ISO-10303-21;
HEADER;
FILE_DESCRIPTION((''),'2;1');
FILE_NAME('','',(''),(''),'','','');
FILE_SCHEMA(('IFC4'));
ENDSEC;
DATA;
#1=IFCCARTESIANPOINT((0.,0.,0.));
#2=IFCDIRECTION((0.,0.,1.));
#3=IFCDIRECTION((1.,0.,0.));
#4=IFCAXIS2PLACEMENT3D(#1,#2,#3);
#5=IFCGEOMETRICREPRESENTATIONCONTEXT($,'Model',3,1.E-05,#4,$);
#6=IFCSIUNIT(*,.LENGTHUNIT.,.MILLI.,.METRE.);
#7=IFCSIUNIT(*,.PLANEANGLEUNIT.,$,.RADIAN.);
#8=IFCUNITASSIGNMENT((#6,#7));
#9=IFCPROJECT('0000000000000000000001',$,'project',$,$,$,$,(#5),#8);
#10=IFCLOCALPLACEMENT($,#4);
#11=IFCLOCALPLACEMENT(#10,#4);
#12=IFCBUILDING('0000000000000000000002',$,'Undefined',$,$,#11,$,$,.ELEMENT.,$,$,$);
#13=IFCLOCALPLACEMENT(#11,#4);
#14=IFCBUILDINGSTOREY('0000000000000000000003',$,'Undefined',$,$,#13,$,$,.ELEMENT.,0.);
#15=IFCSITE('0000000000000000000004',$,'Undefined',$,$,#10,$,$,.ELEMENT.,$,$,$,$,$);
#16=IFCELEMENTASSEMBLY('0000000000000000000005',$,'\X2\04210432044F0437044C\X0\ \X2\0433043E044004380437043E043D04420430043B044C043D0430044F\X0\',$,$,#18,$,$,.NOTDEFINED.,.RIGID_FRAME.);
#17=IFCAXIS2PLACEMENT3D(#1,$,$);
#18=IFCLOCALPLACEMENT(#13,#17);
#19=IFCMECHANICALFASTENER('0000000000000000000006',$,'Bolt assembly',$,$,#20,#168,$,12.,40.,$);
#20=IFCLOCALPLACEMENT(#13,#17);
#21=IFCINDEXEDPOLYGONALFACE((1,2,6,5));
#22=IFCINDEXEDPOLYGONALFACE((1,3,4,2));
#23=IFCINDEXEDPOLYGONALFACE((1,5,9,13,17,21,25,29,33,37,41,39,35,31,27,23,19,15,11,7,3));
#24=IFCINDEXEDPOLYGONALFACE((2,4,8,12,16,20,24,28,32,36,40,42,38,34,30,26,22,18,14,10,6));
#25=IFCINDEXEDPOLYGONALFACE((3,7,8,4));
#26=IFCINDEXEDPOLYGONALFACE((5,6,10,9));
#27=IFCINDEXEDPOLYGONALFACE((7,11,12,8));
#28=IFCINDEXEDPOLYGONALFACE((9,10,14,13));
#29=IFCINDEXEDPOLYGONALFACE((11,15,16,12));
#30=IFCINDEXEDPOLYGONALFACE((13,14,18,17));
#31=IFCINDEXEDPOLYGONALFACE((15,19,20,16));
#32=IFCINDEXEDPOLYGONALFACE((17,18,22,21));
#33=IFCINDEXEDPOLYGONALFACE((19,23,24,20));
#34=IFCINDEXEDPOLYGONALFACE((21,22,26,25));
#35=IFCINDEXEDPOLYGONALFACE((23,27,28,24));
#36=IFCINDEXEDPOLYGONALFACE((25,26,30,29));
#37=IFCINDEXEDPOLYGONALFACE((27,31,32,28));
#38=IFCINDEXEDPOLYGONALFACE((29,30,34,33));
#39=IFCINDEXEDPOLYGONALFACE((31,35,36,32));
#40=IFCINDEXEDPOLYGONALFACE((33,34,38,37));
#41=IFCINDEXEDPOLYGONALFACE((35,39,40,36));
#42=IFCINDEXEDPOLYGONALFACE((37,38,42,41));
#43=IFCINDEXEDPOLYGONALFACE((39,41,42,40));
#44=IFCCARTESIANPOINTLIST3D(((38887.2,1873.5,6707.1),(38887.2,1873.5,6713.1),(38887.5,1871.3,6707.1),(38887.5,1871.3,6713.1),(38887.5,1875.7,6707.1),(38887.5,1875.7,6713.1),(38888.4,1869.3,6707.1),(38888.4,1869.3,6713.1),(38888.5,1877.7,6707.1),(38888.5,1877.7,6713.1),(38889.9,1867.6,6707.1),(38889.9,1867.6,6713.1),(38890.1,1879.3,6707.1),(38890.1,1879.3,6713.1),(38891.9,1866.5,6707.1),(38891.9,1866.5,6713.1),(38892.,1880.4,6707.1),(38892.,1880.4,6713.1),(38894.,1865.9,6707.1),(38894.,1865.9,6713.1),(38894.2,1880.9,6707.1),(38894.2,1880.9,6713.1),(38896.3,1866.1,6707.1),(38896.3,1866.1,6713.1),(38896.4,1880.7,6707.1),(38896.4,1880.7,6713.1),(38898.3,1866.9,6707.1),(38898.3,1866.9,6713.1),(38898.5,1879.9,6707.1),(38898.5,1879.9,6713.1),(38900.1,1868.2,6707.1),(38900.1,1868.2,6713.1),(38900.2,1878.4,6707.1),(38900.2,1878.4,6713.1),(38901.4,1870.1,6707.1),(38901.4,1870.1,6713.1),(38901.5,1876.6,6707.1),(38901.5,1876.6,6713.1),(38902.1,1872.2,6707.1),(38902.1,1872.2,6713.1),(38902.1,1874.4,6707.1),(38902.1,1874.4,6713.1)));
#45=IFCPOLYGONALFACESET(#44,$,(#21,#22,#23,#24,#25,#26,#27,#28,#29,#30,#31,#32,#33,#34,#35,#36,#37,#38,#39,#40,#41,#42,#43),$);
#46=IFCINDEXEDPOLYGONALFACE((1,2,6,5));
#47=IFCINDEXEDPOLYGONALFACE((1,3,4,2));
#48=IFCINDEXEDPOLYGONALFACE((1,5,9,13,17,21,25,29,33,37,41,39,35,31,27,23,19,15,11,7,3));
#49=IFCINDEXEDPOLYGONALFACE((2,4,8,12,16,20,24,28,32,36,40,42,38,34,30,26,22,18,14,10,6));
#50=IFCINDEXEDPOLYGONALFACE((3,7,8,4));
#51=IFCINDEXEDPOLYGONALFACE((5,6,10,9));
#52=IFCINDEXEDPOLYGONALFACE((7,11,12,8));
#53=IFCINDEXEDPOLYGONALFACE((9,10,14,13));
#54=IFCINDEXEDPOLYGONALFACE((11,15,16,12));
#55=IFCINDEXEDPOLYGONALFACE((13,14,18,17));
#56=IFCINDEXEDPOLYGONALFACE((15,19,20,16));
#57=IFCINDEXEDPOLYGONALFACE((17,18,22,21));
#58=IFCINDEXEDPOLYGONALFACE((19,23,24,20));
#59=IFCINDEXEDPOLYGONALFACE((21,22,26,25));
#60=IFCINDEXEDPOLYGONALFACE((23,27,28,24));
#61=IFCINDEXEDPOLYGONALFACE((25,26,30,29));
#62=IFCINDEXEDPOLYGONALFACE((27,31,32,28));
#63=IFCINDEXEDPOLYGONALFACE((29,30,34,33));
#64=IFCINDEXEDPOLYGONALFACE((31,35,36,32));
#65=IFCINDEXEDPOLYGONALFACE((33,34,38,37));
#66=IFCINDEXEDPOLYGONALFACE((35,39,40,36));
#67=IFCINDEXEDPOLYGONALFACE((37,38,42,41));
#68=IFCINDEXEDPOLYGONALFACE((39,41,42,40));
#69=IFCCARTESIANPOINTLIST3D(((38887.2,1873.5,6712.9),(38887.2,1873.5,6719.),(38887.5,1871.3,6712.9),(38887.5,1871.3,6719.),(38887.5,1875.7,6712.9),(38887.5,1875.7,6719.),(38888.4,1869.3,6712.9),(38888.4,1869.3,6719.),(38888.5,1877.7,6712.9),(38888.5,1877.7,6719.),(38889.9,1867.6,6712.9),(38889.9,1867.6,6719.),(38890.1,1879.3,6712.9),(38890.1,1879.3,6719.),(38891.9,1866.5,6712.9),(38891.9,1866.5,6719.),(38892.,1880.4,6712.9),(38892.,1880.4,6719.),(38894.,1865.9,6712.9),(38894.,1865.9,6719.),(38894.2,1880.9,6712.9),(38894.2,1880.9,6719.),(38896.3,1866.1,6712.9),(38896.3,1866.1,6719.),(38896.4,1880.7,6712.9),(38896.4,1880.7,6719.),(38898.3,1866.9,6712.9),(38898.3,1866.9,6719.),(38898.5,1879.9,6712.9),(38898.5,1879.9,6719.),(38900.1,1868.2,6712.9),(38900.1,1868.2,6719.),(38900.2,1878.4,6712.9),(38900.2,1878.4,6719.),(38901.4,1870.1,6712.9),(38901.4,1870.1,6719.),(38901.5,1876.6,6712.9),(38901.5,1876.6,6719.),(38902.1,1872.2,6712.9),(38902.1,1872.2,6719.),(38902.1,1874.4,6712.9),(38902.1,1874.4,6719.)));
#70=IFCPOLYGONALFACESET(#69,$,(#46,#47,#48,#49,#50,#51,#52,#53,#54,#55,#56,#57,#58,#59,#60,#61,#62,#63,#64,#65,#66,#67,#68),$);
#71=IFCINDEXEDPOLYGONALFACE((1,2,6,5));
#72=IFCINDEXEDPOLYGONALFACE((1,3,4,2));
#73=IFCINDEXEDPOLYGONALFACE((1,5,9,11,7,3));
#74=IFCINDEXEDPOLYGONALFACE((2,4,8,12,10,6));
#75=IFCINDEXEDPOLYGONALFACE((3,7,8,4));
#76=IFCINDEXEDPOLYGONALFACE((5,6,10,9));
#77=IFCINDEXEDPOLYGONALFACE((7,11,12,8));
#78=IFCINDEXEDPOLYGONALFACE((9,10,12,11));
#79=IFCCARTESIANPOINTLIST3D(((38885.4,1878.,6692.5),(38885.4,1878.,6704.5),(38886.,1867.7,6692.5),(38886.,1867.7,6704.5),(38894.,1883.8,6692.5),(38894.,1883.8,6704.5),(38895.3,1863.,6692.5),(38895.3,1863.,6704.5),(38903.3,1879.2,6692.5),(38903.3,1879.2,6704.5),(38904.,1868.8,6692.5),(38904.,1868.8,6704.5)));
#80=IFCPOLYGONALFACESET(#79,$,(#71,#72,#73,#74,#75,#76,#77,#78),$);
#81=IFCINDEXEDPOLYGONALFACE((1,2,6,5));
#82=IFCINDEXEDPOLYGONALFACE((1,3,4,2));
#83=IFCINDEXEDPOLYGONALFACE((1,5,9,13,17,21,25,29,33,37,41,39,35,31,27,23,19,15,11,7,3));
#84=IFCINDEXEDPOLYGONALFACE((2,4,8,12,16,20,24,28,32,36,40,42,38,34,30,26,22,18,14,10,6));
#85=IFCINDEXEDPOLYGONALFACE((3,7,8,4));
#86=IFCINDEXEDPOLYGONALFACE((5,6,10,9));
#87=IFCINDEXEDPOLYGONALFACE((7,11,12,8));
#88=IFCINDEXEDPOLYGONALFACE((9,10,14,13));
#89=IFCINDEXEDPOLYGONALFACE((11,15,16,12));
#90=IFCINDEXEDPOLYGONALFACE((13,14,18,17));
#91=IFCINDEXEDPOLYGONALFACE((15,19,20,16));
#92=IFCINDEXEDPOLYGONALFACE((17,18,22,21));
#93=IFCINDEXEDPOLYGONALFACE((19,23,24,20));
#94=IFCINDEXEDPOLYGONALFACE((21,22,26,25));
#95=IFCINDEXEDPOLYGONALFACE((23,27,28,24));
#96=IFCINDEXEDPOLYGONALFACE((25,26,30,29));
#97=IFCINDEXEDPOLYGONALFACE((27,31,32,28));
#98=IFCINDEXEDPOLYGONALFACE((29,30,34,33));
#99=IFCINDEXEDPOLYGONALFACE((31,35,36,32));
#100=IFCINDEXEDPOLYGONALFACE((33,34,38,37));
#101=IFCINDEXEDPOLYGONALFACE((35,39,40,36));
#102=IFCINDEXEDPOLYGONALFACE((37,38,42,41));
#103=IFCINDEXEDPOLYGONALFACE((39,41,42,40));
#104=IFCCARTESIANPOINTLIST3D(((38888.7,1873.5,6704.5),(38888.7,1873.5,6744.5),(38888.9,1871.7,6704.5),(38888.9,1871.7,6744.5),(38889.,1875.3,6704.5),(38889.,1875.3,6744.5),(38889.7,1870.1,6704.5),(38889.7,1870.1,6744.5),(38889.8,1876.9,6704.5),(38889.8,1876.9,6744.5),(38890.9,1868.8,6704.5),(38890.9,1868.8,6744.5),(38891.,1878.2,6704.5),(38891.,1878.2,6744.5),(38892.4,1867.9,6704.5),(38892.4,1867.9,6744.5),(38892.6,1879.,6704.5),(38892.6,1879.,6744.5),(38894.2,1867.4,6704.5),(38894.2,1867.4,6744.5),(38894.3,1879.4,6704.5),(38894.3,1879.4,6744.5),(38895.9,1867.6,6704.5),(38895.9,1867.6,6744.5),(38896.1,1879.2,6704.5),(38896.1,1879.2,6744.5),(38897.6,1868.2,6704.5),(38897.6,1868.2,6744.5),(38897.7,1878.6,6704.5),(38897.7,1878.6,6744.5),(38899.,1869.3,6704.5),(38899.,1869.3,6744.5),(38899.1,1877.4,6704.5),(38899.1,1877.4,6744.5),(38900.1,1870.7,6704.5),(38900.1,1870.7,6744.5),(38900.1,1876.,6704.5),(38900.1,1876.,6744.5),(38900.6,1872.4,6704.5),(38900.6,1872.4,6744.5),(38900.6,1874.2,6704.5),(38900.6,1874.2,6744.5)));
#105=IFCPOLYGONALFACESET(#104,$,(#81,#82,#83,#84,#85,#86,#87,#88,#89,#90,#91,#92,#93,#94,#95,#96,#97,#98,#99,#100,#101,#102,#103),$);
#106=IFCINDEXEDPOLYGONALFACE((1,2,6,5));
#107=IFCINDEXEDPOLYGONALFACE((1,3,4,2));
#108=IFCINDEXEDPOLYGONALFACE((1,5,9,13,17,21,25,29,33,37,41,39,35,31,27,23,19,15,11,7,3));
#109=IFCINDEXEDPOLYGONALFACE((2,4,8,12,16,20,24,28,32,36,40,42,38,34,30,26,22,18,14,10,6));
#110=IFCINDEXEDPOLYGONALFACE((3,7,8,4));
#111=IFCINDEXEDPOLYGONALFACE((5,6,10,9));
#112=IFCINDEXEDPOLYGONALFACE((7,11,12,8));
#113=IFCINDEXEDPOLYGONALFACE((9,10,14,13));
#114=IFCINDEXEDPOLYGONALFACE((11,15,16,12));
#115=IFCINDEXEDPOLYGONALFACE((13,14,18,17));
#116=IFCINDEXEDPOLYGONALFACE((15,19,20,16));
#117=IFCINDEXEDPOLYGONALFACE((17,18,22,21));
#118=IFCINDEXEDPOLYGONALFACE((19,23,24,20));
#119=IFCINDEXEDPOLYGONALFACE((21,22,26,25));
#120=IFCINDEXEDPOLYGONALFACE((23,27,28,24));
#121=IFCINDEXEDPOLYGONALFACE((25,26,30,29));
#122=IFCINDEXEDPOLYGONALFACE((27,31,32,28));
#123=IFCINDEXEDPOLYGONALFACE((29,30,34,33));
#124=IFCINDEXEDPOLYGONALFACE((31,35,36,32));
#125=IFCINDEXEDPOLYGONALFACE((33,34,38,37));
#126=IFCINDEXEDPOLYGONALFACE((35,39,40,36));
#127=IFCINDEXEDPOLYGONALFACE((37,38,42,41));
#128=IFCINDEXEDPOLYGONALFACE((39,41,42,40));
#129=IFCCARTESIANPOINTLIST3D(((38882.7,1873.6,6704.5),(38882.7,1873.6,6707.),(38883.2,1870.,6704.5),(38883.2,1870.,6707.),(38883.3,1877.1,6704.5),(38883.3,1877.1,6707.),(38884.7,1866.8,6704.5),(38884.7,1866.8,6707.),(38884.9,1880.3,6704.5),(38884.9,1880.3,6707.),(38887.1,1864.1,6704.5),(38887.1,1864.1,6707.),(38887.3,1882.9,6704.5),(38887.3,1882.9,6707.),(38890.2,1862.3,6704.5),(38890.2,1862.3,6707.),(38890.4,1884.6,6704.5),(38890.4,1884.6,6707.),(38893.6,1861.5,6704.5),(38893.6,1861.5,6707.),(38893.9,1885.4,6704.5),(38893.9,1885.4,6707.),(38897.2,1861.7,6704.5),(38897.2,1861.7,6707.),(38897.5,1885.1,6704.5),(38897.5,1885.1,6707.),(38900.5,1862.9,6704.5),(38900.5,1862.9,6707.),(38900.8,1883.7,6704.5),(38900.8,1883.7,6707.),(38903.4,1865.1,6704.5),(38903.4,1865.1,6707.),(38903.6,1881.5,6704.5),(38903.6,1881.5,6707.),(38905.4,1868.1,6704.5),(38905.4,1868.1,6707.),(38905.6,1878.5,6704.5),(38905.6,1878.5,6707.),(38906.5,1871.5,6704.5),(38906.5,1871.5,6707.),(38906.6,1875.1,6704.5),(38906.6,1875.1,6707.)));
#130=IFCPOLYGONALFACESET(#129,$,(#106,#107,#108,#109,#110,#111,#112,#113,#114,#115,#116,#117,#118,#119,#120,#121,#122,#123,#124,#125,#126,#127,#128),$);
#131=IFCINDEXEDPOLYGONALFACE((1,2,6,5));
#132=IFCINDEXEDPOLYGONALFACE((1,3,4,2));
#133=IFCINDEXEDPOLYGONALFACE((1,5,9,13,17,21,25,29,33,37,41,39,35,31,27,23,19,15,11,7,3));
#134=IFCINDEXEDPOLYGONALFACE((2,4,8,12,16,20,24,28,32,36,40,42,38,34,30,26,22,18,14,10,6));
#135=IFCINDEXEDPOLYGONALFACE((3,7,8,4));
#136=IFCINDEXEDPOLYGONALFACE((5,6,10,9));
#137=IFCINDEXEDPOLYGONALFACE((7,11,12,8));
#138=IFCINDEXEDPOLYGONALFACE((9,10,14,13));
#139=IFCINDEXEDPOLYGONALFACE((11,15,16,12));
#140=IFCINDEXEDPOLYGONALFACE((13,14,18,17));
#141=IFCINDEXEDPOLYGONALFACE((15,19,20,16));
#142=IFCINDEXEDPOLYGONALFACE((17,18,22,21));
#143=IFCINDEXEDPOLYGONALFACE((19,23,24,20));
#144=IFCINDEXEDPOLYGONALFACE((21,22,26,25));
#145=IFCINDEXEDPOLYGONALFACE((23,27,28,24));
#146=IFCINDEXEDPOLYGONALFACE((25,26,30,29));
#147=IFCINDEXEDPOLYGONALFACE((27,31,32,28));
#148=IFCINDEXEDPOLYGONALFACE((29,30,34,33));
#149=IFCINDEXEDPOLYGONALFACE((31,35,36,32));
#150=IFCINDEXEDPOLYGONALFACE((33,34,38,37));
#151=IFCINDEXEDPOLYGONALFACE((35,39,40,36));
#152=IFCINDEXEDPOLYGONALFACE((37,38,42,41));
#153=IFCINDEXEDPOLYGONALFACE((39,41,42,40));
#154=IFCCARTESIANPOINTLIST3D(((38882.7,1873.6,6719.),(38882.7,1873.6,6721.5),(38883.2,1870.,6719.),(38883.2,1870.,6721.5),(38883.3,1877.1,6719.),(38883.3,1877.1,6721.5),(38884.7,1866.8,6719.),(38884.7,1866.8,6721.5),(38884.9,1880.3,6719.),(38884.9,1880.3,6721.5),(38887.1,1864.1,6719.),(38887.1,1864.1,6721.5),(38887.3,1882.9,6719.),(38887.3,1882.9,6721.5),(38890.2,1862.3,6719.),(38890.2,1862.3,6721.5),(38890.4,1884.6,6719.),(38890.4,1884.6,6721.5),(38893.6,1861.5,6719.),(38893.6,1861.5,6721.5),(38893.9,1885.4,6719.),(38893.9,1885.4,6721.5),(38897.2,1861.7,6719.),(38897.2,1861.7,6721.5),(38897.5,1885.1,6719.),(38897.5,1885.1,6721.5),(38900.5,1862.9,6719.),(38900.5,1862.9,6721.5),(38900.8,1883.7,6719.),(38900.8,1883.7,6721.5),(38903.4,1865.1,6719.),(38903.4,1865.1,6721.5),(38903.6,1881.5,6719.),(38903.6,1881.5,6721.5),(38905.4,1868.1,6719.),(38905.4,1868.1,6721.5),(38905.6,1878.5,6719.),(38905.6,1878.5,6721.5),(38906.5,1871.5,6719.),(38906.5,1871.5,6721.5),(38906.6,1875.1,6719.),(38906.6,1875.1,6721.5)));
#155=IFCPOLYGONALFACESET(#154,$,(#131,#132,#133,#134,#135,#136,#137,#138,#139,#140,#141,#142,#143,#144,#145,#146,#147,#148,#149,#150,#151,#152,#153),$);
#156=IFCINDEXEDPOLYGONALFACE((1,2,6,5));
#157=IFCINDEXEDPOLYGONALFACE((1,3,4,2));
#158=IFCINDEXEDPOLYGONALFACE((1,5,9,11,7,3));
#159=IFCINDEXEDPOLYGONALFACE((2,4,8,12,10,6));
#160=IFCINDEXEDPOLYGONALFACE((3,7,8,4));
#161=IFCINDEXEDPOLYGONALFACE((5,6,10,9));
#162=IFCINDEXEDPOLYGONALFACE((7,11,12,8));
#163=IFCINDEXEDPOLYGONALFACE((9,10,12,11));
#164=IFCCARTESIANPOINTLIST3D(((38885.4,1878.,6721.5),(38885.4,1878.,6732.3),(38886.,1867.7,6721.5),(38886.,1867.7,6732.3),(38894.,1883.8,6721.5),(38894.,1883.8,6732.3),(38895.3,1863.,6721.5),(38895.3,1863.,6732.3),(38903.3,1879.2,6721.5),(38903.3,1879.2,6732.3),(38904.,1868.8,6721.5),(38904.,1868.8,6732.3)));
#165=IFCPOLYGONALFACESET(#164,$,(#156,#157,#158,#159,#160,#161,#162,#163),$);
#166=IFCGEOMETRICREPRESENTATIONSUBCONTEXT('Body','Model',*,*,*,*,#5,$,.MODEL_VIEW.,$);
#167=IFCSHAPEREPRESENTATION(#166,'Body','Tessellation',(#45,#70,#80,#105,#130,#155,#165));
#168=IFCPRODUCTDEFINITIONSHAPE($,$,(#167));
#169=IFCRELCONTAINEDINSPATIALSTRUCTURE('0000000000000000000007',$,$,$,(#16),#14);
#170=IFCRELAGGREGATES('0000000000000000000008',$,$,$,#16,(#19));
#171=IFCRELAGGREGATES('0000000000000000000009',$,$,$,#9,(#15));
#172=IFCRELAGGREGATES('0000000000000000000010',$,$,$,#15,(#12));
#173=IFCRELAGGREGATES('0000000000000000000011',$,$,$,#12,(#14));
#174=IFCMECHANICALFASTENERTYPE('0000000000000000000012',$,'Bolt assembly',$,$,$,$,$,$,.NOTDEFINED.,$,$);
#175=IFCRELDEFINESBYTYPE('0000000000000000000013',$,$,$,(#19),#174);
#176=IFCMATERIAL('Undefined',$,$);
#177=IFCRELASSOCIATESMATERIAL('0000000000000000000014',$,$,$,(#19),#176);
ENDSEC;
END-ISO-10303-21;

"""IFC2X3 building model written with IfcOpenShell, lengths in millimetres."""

from ifc_helpers import new_model, si_unit, frame, origin_with_axes, origin_2d_with_axis, place, context, subcontext, project, spatial, polyline, circle, outline, extrude, source, transform, mapped, material, type_object, element, aggregate, save


model = new_model("IFC2X3")

# Units and contexts
model_context = context("Model", 3, precision=1e-05, world=origin_with_axes())
body_context = subcontext(model_context, "Body", "Model", "MODEL_VIEW")
ifc_project = project(units=[si_unit("LENGTHUNIT", "METRE", prefix="MILLI"), si_unit("PLANEANGLEUNIT", "RADIAN")], contexts=[model_context])

# Site, building, storey
site_placement = place(None, origin_with_axes())
site = spatial("IfcSite", under=ifc_project, at=site_placement, Name="Undefined", CompositionType="ELEMENT")
building_placement = place(site_placement, origin_with_axes())
building = spatial("IfcBuilding", under=site, at=building_placement, Name="Undefined", CompositionType="ELEMENT")
storey_placement = place(building_placement, origin_with_axes())
storey = spatial("IfcBuildingStorey", under=building, at=storey_placement, Name="Undefined", CompositionType="ELEMENT", Elevation=0.0)

# Element assembly
assembly_1_placement = place(storey_placement, origin_with_axes())
assembly_1 = element("IfcElementAssembly", 1, at=assembly_1_placement, inside=storey, Name="Связь горизонтальная", AssemblyPlace="NOTDEFINED", PredefinedType="RIGID_FRAME")

# Mechanical fastener
ifc_material_1 = material(Name="Undefined")
mechanical_fastener_type = type_object("IfcMechanicalFastenerType", Name="Bolt assembly")
shared_shape_1 = source(origin_with_axes(), body_context, "Body", "SweptSolid", [
    extrude(circle(Radius=7.5, at=origin_2d_with_axis()), frame((0.0, 0.1, 0.0), z_axis=(0.0, 1.0, 0.0), x_axis=(1.0, 0.0, 0.0)), (0.0, 0.0, 1.0), 6.0),
    extrude(circle(Radius=7.5, at=origin_2d_with_axis()), frame((0.0, 5.9, 0.0), z_axis=(0.0, 1.0, 0.0), x_axis=(1.0, 0.0, 0.0)), (0.0, 0.0, 1.0), 6.1),
    extrude(outline(polyline([(10.4, 0.0), (5.2, 9.0), (-5.2, 9.0), (-10.4, 0.0), (-5.2, -9.0), (5.2, -9.0), (10.4, 0.0)])), frame((0.0, -14.5, 0.0), z_axis=(0.0, 1.0, 0.0), x_axis=(1.0, 0.0, 0.0)), (0.0, 0.0, 1.0), 12.0),
    extrude(circle(Radius=6.0, at=origin_2d_with_axis()), frame((0.0, -2.5, 0.0), z_axis=(0.0, 1.0, 0.0), x_axis=(1.0, 0.0, 0.0)), (0.0, 0.0, 1.0), 40.0),
    extrude(circle(Radius=12.0, at=origin_2d_with_axis()), frame((0.0, -2.5, 0.0), z_axis=(0.0, 1.0, 0.0), x_axis=(1.0, 0.0, 0.0)), (0.0, 0.0, 1.0), 2.5),
    extrude(circle(Radius=12.0, at=origin_2d_with_axis()), frame((0.0, 12.0, 0.0), z_axis=(0.0, 1.0, 0.0), x_axis=(1.0, 0.0, 0.0)), (0.0, 0.0, 1.0), 2.5),
    extrude(outline(polyline([(10.4, 0.0), (5.2, 9.0), (-5.2, 9.0), (-10.4, 0.0), (-5.2, -9.0), (5.2, -9.0), (10.4, 0.0)])), frame((0.0, 14.5, 0.0), z_axis=(0.0, 1.0, 0.0), x_axis=(1.0, 0.0, 0.0)), (0.0, 0.0, 1.0), 10.8),
])
mechanical_fastener_1_placement = place(assembly_1_placement, frame((38894.7, 1873.4, 6707.0), z_axis=(-0.552695, 0.833383, 0.0), x_axis=(-0.833383, -0.552695, 0.0)))
mechanical_fastener_1 = element("IfcMechanicalFastener", 2, at=mechanical_fastener_1_placement, type_object=mechanical_fastener_type, material=ifc_material_1, Name="Bolt assembly", NominalDiameter=12.0, NominalLength=40.0, context=body_context, shape_type="MappedRepresentation", body=[
    mapped(shared_shape_1, transform((0.0, 0.0, 0.0))),
])
aggregate(assembly_1, [mechanical_fastener_1])

save(model, "model.ifc")
